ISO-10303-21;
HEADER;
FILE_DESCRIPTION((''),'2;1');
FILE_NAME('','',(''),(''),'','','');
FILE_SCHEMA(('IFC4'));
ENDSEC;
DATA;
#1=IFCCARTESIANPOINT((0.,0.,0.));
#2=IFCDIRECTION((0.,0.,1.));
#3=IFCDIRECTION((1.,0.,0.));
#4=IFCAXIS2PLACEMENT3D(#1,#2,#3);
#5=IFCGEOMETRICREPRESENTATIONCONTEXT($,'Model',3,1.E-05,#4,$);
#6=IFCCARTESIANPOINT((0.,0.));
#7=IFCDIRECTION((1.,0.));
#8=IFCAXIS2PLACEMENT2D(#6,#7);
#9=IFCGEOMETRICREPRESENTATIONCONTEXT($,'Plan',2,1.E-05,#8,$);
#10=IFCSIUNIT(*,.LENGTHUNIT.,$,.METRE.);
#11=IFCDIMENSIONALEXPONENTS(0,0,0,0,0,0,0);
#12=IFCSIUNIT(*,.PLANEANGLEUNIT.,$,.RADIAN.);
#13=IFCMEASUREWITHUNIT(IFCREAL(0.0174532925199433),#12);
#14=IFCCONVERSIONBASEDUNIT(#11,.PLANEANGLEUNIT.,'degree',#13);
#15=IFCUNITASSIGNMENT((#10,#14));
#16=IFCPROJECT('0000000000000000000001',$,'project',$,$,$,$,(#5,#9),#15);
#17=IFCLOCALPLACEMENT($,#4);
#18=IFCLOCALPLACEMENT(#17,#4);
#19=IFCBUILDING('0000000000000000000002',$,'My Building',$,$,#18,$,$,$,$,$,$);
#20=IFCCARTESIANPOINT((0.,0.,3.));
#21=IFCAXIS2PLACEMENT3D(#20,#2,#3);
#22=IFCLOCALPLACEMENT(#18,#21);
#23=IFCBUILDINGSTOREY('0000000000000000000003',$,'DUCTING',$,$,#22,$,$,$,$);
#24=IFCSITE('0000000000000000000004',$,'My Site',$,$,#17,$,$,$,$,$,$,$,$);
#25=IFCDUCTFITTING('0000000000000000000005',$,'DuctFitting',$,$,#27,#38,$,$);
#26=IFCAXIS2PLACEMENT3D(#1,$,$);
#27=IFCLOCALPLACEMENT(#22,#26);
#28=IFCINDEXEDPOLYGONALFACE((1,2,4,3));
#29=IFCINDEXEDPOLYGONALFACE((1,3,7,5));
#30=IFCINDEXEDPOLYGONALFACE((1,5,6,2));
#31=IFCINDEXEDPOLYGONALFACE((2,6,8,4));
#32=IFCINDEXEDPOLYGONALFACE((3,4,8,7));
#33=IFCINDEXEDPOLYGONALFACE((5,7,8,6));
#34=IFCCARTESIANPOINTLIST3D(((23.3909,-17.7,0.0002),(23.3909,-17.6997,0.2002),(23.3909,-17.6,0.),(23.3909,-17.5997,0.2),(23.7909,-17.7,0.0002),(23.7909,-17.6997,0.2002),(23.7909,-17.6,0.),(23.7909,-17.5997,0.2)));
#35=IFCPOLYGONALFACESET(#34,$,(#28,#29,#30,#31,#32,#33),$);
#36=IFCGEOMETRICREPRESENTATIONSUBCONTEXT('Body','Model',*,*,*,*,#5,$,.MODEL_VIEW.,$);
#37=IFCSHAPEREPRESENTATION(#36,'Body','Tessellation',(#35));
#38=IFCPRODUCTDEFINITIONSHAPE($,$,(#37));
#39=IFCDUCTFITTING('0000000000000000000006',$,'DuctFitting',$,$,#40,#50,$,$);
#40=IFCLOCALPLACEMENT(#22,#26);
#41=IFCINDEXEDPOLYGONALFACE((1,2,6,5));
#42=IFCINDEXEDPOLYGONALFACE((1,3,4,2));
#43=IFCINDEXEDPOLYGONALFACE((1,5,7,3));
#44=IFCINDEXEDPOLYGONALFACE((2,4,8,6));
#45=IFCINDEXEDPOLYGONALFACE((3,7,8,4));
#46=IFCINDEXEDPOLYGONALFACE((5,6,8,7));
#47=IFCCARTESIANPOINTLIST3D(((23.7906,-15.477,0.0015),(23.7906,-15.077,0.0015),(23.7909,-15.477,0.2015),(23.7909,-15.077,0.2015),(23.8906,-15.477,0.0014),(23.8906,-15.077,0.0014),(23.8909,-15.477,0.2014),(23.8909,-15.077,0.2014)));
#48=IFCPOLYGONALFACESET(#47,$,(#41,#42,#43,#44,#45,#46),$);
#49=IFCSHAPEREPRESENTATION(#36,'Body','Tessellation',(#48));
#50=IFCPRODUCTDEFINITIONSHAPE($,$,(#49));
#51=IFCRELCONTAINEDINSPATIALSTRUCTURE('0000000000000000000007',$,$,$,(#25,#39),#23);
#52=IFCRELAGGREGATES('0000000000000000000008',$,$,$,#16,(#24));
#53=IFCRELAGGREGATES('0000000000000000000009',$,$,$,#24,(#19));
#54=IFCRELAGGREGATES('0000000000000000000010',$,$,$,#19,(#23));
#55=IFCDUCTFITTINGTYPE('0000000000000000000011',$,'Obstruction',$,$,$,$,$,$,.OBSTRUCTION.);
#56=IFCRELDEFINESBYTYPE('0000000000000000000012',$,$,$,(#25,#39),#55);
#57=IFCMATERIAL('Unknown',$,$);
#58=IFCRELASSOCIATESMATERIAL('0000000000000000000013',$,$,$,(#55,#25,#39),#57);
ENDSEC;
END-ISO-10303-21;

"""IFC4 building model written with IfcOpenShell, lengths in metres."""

from ifc_helpers import new_model, entity, si_unit, converted_unit, frame, origin_with_axes, origin_2d_with_axis, place, context, subcontext, project, spatial, rectangle, extrude, material, material_profile, profile_set, profile_usage, type_object, element, save


model = new_model("IFC4")

# Units and contexts
model_context = context("Model", 3, precision=1e-05, world=origin_with_axes())
plan_context = context("Plan", 2, precision=1e-05, world=origin_2d_with_axis())
body_context = subcontext(model_context, "Body", "Model", "MODEL_VIEW")
ifc_project = project(units=[si_unit("LENGTHUNIT", "METRE"), converted_unit("PLANEANGLEUNIT", "degree", entity("IfcReal", 0.0174532925199433), si_unit("PLANEANGLEUNIT", "RADIAN"), dimensions=[0, 0, 0, 0, 0, 0, 0])], contexts=[model_context, plan_context])

# Site, building, storey
site_placement = place(None, origin_with_axes())
site = spatial("IfcSite", under=ifc_project, at=site_placement, Name="My Site")
building_placement = place(site_placement, origin_with_axes())
building = spatial("IfcBuilding", under=site, at=building_placement, Name="My Building")
storey_placement = place(building_placement, frame((0.0, 0.0, 3.0), z_axis=(0.0, 0.0, 1.0), x_axis=(1.0, 0.0, 0.0)))
storey = spatial("IfcBuildingStorey", under=building, at=storey_placement, Name="DUCTING")

# Shared definitions
ifc_material = material(Name="Unknown")

# Duct fittings
ifc_material_profile_1 = material_profile(ifc_material, rectangle(XDim=0.4, YDim=0.2))
ifc_profile_set_1 = profile_set([ifc_material_profile_1])
duct_fitting_type_1 = type_object("IfcDuctFittingType", Name="Obstruction", PredefinedType="OBSTRUCTION", material=ifc_profile_set_1)
ifc_profile_usage_1 = profile_usage(ifc_profile_set_1, cardinal=5)
duct_fitting_1_placement = place(storey_placement, frame((23.5909, -17.6999, 0.1002), z_axis=(0.0, 0.999998, -0.001745), x_axis=(-1.0, 0.0, 0.0)))
element("IfcDuctFitting", 1, at=duct_fitting_1_placement, inside=storey, type_object=duct_fitting_type_1, material=ifc_profile_usage_1, Name="DuctFitting", context=body_context, shape_type="SweptSolid", body=[
    extrude(rectangle(XDim=0.4, YDim=0.2), origin_with_axes(), (0.0, 0.0, 1.0), 0.1),
])
ifc_profile_usage_2 = profile_usage(ifc_profile_set_1, cardinal=5)
duct_fitting_2_placement = place(storey_placement, frame((23.7907, -15.277, 0.1015), z_axis=(0.999998, 0.0, -0.001745), x_axis=(0.0, 1.0, 0.0)))
element("IfcDuctFitting", 2, at=duct_fitting_2_placement, inside=storey, type_object=duct_fitting_type_1, material=ifc_profile_usage_2, Name="DuctFitting", context=body_context, shape_type="SweptSolid", body=[
    extrude(rectangle(XDim=0.4, YDim=0.2), origin_with_axes(), (0.0, 0.0, 1.0), 0.1),
])

save(model, "model.ifc")
